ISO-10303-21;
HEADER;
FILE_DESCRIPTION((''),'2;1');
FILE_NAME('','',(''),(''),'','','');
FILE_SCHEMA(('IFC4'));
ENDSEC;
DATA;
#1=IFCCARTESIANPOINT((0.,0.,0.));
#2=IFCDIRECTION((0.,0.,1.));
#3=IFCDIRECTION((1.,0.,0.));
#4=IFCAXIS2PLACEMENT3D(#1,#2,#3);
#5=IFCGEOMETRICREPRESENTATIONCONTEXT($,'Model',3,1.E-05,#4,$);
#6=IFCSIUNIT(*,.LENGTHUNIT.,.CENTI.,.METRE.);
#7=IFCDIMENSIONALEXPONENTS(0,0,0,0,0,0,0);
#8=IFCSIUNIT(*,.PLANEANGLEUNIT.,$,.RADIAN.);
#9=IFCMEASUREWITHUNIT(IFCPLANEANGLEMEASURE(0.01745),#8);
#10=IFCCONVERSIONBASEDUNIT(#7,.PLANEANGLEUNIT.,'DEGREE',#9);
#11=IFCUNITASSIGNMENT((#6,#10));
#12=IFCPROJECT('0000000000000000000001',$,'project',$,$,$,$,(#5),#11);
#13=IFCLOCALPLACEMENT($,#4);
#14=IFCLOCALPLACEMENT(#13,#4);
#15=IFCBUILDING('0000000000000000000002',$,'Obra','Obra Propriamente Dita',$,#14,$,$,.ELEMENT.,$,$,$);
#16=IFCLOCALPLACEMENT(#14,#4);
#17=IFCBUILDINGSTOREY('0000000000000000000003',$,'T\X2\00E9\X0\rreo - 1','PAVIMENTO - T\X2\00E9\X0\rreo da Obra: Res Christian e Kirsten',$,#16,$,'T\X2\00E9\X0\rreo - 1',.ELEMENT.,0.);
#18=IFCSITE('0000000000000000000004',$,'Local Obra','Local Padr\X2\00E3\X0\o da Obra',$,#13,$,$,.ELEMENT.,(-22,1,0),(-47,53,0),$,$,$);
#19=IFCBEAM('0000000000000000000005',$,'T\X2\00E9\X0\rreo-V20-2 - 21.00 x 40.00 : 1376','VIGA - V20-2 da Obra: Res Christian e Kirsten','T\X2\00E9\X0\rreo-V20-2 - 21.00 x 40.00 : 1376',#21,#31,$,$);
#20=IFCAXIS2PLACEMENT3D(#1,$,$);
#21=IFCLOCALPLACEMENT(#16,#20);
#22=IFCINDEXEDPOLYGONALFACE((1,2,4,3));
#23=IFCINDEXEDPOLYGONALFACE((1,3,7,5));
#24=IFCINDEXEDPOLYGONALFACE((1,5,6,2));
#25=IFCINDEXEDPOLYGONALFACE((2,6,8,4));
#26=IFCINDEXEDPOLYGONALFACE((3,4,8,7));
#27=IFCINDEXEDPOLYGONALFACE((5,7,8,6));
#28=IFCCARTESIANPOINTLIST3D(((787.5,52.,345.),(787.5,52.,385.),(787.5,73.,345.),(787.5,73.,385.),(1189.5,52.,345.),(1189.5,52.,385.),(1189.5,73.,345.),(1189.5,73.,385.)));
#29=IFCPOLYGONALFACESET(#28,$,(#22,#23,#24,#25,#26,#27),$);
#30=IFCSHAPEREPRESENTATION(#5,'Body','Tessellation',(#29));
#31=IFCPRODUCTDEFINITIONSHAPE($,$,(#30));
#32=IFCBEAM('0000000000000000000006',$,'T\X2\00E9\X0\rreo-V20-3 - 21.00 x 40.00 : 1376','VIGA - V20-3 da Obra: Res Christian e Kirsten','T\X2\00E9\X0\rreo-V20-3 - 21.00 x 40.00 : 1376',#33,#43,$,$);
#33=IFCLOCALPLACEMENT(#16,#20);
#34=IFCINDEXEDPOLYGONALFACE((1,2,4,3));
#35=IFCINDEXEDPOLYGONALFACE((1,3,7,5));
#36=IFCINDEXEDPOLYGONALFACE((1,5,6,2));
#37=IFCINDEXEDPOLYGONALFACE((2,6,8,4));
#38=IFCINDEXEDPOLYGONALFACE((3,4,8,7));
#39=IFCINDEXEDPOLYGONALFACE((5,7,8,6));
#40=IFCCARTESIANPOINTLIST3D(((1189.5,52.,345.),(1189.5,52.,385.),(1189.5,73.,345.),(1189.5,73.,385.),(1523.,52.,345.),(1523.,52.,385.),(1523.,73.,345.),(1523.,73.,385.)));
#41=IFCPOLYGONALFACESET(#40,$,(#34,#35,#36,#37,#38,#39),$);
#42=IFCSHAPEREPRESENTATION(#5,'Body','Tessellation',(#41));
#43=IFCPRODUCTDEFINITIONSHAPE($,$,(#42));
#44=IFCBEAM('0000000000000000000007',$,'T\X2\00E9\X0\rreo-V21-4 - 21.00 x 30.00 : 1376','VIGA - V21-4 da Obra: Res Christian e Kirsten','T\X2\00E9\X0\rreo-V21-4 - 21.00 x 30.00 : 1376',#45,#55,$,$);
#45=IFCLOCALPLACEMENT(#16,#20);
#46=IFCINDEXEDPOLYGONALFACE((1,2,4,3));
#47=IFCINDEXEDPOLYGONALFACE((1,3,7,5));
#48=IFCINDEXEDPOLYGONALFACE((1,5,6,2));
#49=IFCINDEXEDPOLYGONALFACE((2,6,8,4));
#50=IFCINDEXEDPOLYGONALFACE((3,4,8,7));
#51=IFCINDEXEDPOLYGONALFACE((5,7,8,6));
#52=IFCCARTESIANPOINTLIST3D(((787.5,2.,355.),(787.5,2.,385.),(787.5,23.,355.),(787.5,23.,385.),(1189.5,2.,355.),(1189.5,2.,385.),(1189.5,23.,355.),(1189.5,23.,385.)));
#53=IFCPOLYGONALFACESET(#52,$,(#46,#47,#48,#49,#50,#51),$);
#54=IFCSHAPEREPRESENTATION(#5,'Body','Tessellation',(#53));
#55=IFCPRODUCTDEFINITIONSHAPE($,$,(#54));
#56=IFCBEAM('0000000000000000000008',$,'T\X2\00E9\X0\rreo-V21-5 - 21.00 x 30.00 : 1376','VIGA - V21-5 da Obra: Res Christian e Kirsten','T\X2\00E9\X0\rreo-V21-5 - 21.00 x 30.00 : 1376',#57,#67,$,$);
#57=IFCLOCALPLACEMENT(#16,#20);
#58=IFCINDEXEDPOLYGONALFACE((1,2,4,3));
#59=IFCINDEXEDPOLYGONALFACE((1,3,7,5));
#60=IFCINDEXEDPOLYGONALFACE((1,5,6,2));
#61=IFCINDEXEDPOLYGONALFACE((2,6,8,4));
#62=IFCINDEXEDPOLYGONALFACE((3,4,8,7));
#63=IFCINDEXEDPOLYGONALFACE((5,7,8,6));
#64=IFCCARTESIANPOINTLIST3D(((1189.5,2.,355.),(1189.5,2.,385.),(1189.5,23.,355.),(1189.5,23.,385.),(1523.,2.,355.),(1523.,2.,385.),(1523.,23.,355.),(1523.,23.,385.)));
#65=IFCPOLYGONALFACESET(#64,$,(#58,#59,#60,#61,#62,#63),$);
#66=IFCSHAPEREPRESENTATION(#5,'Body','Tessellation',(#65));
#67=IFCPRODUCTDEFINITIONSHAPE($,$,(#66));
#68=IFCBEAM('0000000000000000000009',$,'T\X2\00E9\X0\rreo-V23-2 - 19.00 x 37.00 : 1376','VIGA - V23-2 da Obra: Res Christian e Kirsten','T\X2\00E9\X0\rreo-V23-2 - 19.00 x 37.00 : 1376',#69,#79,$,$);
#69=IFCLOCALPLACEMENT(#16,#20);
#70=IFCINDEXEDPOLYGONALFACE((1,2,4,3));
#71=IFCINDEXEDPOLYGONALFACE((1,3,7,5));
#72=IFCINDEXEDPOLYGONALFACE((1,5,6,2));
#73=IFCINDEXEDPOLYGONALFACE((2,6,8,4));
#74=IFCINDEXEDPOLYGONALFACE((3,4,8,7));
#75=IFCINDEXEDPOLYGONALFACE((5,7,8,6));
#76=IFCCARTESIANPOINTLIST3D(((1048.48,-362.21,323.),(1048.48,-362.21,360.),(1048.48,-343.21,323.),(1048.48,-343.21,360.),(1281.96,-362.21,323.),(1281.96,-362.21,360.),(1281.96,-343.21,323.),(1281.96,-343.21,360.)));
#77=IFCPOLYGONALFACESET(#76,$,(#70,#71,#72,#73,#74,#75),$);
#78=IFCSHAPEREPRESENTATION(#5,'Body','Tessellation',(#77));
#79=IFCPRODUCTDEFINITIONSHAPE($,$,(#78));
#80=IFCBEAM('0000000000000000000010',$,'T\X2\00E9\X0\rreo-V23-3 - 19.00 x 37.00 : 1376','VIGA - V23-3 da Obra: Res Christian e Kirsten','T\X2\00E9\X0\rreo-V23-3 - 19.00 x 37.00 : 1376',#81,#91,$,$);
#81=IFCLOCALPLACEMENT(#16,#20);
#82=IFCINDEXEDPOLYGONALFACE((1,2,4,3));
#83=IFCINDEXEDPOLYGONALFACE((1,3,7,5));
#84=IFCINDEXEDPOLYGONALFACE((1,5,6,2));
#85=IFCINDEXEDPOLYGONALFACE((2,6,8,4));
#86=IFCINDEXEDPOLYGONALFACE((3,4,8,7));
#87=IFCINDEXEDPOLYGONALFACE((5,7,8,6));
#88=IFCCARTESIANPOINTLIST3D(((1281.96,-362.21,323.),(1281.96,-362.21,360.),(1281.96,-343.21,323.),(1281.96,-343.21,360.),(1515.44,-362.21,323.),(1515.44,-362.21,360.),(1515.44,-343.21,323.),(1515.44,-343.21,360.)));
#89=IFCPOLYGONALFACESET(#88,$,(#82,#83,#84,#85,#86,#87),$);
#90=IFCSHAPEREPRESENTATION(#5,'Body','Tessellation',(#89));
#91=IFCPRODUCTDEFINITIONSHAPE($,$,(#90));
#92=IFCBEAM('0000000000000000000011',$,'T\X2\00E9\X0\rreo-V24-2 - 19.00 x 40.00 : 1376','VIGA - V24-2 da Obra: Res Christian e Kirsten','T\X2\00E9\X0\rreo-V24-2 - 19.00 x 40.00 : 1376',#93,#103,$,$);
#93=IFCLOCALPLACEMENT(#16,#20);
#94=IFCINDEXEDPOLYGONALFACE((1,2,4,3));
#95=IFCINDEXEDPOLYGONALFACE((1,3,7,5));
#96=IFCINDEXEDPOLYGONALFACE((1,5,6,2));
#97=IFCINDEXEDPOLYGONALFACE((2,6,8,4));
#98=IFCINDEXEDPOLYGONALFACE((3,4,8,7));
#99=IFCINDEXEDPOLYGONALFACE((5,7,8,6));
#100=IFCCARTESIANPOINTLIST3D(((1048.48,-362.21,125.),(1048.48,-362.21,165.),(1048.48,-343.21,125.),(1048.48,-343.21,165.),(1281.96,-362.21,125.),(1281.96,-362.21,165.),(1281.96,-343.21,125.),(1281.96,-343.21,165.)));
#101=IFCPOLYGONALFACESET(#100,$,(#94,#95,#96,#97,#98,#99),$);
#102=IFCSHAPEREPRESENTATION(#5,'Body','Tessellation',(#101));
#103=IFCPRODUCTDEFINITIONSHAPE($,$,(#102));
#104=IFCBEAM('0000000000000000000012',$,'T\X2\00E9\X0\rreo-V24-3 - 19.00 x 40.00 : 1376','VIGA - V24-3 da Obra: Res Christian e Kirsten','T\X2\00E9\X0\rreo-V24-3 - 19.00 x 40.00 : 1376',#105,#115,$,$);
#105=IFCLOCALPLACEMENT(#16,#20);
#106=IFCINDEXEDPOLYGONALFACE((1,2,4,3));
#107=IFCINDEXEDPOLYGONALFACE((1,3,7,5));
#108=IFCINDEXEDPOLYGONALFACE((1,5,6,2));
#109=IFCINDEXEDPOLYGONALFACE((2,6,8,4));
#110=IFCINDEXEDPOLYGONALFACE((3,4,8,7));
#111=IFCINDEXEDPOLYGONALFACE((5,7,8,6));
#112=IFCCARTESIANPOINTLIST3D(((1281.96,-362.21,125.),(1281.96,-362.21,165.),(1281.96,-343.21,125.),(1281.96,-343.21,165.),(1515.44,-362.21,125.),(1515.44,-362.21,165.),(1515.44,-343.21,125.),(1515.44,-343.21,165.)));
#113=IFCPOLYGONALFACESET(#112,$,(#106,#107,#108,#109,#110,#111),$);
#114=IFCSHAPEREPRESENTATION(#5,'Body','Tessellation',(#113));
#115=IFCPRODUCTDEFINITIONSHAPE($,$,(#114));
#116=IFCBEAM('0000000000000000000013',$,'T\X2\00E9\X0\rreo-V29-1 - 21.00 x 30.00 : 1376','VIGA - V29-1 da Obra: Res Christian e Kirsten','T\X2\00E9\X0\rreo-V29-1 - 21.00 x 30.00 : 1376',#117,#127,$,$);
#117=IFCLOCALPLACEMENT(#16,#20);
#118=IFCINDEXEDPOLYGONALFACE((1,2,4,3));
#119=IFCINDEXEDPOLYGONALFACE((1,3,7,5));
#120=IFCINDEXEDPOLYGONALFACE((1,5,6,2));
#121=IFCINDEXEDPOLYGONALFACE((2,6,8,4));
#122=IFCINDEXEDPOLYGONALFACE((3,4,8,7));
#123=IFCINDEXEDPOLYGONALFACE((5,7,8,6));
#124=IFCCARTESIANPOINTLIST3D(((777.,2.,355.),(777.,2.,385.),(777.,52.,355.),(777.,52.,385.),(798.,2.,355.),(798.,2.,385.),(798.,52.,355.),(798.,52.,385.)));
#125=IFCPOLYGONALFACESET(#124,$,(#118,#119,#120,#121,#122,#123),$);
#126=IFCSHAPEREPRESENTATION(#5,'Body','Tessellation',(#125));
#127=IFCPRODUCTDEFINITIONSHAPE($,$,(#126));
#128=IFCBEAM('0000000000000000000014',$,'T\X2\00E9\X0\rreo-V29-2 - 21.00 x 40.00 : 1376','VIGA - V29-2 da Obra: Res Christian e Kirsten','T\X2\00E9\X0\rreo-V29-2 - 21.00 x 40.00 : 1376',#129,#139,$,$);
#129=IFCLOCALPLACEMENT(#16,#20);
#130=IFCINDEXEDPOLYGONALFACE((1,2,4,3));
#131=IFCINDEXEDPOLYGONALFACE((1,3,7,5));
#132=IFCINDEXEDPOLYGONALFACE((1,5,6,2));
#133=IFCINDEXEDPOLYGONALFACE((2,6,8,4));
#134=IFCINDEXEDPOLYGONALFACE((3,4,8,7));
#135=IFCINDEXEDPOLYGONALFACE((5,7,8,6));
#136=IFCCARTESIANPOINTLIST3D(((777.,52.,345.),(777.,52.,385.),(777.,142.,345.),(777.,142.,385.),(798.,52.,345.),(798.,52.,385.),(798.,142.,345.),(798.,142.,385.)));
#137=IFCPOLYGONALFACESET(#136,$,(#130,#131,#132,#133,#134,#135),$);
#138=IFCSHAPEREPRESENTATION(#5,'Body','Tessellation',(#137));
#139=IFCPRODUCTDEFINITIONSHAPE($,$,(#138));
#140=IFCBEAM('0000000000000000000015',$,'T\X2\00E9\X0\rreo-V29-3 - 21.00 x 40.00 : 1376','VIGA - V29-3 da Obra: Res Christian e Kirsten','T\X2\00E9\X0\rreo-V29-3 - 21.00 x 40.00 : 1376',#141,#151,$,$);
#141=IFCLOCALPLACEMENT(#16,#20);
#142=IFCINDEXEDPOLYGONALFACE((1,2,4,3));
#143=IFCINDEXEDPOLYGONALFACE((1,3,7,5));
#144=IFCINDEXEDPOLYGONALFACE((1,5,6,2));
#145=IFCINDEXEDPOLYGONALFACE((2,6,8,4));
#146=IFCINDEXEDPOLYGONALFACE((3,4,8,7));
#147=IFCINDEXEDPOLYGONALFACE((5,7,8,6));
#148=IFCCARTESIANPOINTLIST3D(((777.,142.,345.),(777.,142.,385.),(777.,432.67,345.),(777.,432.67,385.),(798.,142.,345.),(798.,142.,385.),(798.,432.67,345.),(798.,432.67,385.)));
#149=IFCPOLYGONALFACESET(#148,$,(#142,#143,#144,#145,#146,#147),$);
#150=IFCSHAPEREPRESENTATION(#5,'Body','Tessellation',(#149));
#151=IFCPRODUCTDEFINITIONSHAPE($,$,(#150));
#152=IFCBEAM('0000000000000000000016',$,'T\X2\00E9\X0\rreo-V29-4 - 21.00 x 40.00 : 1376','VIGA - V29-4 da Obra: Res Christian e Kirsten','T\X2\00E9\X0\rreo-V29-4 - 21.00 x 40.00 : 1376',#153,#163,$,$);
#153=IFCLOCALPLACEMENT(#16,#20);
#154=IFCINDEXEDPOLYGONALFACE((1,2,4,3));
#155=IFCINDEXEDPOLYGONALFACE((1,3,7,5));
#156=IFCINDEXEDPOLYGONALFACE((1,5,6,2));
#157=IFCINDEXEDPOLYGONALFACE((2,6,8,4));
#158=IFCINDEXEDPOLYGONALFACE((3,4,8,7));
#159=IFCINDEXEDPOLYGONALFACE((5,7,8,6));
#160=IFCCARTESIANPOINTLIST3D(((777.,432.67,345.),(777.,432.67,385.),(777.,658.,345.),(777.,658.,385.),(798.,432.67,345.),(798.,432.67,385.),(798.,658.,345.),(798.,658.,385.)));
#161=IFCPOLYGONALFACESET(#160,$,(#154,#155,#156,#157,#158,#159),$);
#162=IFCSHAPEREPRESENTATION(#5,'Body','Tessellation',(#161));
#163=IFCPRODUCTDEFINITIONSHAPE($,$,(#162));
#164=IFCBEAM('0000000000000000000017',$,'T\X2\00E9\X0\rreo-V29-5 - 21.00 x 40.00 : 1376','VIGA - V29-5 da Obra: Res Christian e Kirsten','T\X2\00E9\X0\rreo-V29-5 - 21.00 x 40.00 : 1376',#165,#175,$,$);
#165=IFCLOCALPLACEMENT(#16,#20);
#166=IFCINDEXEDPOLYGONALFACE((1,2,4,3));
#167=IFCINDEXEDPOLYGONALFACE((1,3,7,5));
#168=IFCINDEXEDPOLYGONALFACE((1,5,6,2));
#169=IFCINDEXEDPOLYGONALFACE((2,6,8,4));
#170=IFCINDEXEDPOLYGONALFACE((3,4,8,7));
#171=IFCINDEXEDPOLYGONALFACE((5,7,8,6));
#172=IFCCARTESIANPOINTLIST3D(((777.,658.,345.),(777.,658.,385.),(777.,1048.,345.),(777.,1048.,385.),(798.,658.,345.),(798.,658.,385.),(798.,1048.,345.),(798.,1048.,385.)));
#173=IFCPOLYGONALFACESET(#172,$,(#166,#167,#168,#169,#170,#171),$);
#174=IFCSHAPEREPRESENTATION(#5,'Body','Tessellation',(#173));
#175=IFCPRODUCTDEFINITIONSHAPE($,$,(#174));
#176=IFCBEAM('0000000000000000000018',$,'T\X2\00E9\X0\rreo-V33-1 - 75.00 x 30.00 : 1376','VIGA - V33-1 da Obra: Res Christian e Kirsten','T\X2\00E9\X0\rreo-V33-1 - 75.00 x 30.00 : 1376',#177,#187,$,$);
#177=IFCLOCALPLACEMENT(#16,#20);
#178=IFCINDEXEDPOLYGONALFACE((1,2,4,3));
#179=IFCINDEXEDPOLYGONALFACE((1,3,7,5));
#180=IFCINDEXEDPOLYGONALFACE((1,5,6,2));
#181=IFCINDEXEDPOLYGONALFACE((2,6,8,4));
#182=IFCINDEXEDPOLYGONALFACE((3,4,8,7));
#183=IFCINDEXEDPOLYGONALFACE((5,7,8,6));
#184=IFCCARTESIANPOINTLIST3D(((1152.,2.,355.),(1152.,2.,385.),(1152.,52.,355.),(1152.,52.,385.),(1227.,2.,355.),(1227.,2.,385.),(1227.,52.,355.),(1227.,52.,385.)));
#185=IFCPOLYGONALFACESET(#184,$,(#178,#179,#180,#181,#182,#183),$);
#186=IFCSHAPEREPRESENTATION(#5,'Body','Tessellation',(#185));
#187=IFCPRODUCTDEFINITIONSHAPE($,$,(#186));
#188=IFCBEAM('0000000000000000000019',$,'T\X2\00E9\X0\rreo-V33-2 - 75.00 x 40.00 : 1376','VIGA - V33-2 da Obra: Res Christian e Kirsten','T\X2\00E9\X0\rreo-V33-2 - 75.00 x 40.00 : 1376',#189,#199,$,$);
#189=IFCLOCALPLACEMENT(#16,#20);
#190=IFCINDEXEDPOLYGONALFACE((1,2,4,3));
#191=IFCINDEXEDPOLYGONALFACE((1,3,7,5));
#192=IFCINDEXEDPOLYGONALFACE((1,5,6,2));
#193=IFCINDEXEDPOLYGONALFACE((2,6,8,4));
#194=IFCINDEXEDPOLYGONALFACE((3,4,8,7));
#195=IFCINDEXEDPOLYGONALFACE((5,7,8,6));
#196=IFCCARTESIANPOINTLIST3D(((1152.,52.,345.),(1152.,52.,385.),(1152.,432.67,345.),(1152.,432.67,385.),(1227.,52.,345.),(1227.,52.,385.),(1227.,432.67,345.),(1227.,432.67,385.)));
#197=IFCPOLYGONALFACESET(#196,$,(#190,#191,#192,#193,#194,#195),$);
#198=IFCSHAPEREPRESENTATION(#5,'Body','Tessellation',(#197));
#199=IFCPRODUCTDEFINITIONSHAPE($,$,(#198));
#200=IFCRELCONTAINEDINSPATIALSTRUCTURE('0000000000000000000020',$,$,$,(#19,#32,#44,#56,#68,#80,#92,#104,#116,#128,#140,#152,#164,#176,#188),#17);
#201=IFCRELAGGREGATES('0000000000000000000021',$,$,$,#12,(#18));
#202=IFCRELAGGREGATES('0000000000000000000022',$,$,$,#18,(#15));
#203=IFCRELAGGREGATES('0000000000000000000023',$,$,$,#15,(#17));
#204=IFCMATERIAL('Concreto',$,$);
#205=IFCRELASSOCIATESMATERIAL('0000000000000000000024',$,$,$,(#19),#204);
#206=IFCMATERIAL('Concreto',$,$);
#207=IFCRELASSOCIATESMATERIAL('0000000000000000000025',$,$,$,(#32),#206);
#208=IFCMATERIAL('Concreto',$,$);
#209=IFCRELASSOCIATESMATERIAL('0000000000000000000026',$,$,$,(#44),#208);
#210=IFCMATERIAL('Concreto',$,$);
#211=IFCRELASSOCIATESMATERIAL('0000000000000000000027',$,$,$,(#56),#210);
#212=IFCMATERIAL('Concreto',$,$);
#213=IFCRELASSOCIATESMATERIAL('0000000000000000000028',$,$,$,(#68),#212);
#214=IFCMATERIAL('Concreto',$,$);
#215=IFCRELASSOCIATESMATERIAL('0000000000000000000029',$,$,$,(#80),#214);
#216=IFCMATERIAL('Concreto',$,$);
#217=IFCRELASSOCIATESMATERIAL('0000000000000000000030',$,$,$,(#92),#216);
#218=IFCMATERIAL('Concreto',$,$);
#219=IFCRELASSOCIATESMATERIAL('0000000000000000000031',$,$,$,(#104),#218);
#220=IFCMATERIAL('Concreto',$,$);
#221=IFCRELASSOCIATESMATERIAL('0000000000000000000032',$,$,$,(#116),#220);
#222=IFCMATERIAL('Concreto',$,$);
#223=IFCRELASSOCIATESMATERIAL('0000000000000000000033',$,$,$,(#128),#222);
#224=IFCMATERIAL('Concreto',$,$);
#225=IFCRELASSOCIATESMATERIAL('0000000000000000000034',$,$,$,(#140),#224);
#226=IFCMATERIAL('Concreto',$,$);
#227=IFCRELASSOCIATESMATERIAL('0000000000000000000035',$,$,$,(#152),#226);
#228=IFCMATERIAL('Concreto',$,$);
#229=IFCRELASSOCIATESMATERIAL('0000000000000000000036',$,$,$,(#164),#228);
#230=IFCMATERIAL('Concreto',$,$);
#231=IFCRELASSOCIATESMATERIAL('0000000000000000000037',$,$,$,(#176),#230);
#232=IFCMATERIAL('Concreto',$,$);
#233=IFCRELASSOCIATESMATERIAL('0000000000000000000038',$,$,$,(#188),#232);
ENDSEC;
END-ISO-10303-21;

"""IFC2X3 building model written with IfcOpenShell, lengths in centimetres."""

from ifc_helpers import new_model, entity, si_unit, converted_unit, frame, origin_with_axes, place, context, project, spatial, polyline, outline, extrude, material, element, save


model = new_model("IFC2X3")

# Units and contexts
model_context = context("Model", 3, precision=1e-05, world=origin_with_axes())
ifc_project = project(units=[si_unit("LENGTHUNIT", "METRE", prefix="CENTI"), converted_unit("PLANEANGLEUNIT", "DEGREE", entity("IfcPlaneAngleMeasure", 0.01745), si_unit("PLANEANGLEUNIT", "RADIAN"), dimensions=[0, 0, 0, 0, 0, 0, 0])], contexts=[model_context])

# Site, building, storey
site_placement = place(None, origin_with_axes())
site = spatial("IfcSite", under=ifc_project, at=site_placement, Name="Local Obra", Description="Local Padrão da Obra", CompositionType="ELEMENT", RefLatitude=(-22, 1, 0), RefLongitude=(-47, 53, 0))
building_placement = place(site_placement, origin_with_axes())
building = spatial("IfcBuilding", under=site, at=building_placement, Name="Obra", Description="Obra Propriamente Dita", CompositionType="ELEMENT")
storey_placement = place(building_placement, origin_with_axes())
storey = spatial("IfcBuildingStorey", under=building, at=storey_placement, Name="Térreo - 1", Description="PAVIMENTO - Térreo da Obra: Res Christian e Kirsten", LongName="Térreo - 1", CompositionType="ELEMENT", Elevation=0.0)

# Beams
ifc_material_1 = material(Name="Concreto")
beam_1_placement = place(storey_placement, frame((787.5, 52.0, 385.0), z_axis=(1.0, 0.0, 0.0), x_axis=(0.0, -1.0, 0.0)))
element("IfcBeam", 1, at=beam_1_placement, inside=storey, material=ifc_material_1, Name="Térreo-V20-2 - 21.00 x 40.00 : 1376", Description="VIGA - V20-2 da Obra: Res Christian e Kirsten", ObjectType="Térreo-V20-2 - 21.00 x 40.00 : 1376", context=model_context, shape_type="SweptSolid", body=[
    extrude(outline(polyline([(-21.0, 0.0), (0.0, 0.0), (0.0, 40.0), (-21.0, 40.0), (-21.0, 0.0)])), origin_with_axes(), (0.0, 0.0, 1.0), 402.0),
])
ifc_material_2 = material(Name="Concreto")
beam_2_placement = place(storey_placement, frame((1189.5, 52.0, 385.0), z_axis=(1.0, 0.0, 0.0), x_axis=(0.0, -1.0, 0.0)))
element("IfcBeam", 2, at=beam_2_placement, inside=storey, material=ifc_material_2, Name="Térreo-V20-3 - 21.00 x 40.00 : 1376", Description="VIGA - V20-3 da Obra: Res Christian e Kirsten", ObjectType="Térreo-V20-3 - 21.00 x 40.00 : 1376", context=model_context, shape_type="SweptSolid", body=[
    extrude(outline(polyline([(-21.0, 0.0), (0.0, 0.0), (0.0, 40.0), (-21.0, 40.0), (-21.0, 0.0)])), origin_with_axes(), (0.0, 0.0, 1.0), 333.5),
])
ifc_material_3 = material(Name="Concreto")
beam_3_placement = place(storey_placement, frame((787.5, 2.0, 385.0), z_axis=(1.0, 0.0, 0.0), x_axis=(0.0, -1.0, 0.0)))
element("IfcBeam", 3, at=beam_3_placement, inside=storey, material=ifc_material_3, Name="Térreo-V21-4 - 21.00 x 30.00 : 1376", Description="VIGA - V21-4 da Obra: Res Christian e Kirsten", ObjectType="Térreo-V21-4 - 21.00 x 30.00 : 1376", context=model_context, shape_type="SweptSolid", body=[
    extrude(outline(polyline([(-21.0, 0.0), (0.0, 0.0), (0.0, 30.0), (-21.0, 30.0), (-21.0, 0.0)])), origin_with_axes(), (0.0, 0.0, 1.0), 402.0),
])
ifc_material_4 = material(Name="Concreto")
beam_4_placement = place(storey_placement, frame((1189.5, 2.0, 385.0), z_axis=(1.0, 0.0, 0.0), x_axis=(0.0, -1.0, 0.0)))
element("IfcBeam", 4, at=beam_4_placement, inside=storey, material=ifc_material_4, Name="Térreo-V21-5 - 21.00 x 30.00 : 1376", Description="VIGA - V21-5 da Obra: Res Christian e Kirsten", ObjectType="Térreo-V21-5 - 21.00 x 30.00 : 1376", context=model_context, shape_type="SweptSolid", body=[
    extrude(outline(polyline([(-21.0, 0.0), (0.0, 0.0), (0.0, 30.0), (-21.0, 30.0), (-21.0, 0.0)])), origin_with_axes(), (0.0, 0.0, 1.0), 333.5),
])
ifc_material_5 = material(Name="Concreto")
beam_5_placement = place(storey_placement, frame((1048.48, -362.21, 360.0), z_axis=(1.0, 0.0, 0.0), x_axis=(0.0, -1.0, 0.0)))
element("IfcBeam", 5, at=beam_5_placement, inside=storey, material=ifc_material_5, Name="Térreo-V23-2 - 19.00 x 37.00 : 1376", Description="VIGA - V23-2 da Obra: Res Christian e Kirsten", ObjectType="Térreo-V23-2 - 19.00 x 37.00 : 1376", context=model_context, shape_type="SweptSolid", body=[
    extrude(outline(polyline([(-19.0, 0.0), (0.0, 0.0), (0.0, 37.0), (-19.0, 37.0), (-19.0, 0.0)])), origin_with_axes(), (0.0, 0.0, 1.0), 233.48),
])
ifc_material_6 = material(Name="Concreto")
beam_6_placement = place(storey_placement, frame((1281.96, -362.21, 360.0), z_axis=(1.0, 0.0, 0.0), x_axis=(0.0, -1.0, 0.0)))
element("IfcBeam", 6, at=beam_6_placement, inside=storey, material=ifc_material_6, Name="Térreo-V23-3 - 19.00 x 37.00 : 1376", Description="VIGA - V23-3 da Obra: Res Christian e Kirsten", ObjectType="Térreo-V23-3 - 19.00 x 37.00 : 1376", context=model_context, shape_type="SweptSolid", body=[
    extrude(outline(polyline([(-19.0, 0.0), (0.0, 0.0), (0.0, 37.0), (-19.0, 37.0), (-19.0, 0.0)])), origin_with_axes(), (0.0, 0.0, 1.0), 233.48),
])
ifc_material_7 = material(Name="Concreto")
beam_7_placement = place(storey_placement, frame((1048.48, -362.21, 165.0), z_axis=(1.0, 0.0, 0.0), x_axis=(0.0, -1.0, 0.0)))
element("IfcBeam", 7, at=beam_7_placement, inside=storey, material=ifc_material_7, Name="Térreo-V24-2 - 19.00 x 40.00 : 1376", Description="VIGA - V24-2 da Obra: Res Christian e Kirsten", ObjectType="Térreo-V24-2 - 19.00 x 40.00 : 1376", context=model_context, shape_type="SweptSolid", body=[
    extrude(outline(polyline([(-19.0, 0.0), (0.0, 0.0), (0.0, 40.0), (-19.0, 40.0), (-19.0, 0.0)])), origin_with_axes(), (0.0, 0.0, 1.0), 233.48),
])
ifc_material_8 = material(Name="Concreto")
beam_8_placement = place(storey_placement, frame((1281.96, -362.21, 165.0), z_axis=(1.0, 0.0, 0.0), x_axis=(0.0, -1.0, 0.0)))
element("IfcBeam", 8, at=beam_8_placement, inside=storey, material=ifc_material_8, Name="Térreo-V24-3 - 19.00 x 40.00 : 1376", Description="VIGA - V24-3 da Obra: Res Christian e Kirsten", ObjectType="Térreo-V24-3 - 19.00 x 40.00 : 1376", context=model_context, shape_type="SweptSolid", body=[
    extrude(outline(polyline([(-19.0, 0.0), (0.0, 0.0), (0.0, 40.0), (-19.0, 40.0), (-19.0, 0.0)])), origin_with_axes(), (0.0, 0.0, 1.0), 233.48),
])
ifc_material_9 = material(Name="Concreto")
beam_9_placement = place(storey_placement, frame((787.5, 2.0, 385.0), z_axis=(0.0, 1.0, 0.0), x_axis=(1.0, 0.0, 0.0)))
element("IfcBeam", 9, at=beam_9_placement, inside=storey, material=ifc_material_9, Name="Térreo-V29-1 - 21.00 x 30.00 : 1376", Description="VIGA - V29-1 da Obra: Res Christian e Kirsten", ObjectType="Térreo-V29-1 - 21.00 x 30.00 : 1376", context=model_context, shape_type="SweptSolid", body=[
    extrude(outline(polyline([(-10.5, 0.0), (10.5, 0.0), (10.5, 30.0), (-10.5, 30.0), (-10.5, 0.0)])), origin_with_axes(), (0.0, 0.0, 1.0), 50.0),
])
ifc_material_10 = material(Name="Concreto")
beam_10_placement = place(storey_placement, frame((787.5, 52.0, 385.0), z_axis=(-0.000002, 1.0, 0.0), x_axis=(1.0, 0.000002, 0.0)))
element("IfcBeam", 10, at=beam_10_placement, inside=storey, material=ifc_material_10, Name="Térreo-V29-2 - 21.00 x 40.00 : 1376", Description="VIGA - V29-2 da Obra: Res Christian e Kirsten", ObjectType="Térreo-V29-2 - 21.00 x 40.00 : 1376", context=model_context, shape_type="SweptSolid", body=[
    extrude(outline(polyline([(-10.5, 0.0), (10.5, 0.0), (10.5, 40.0), (-10.5, 40.0), (-10.5, 0.0)])), origin_with_axes(), (0.0, 0.0, 1.0), 90.0),
])
ifc_material_11 = material(Name="Concreto")
beam_11_placement = place(storey_placement, frame((787.5, 142.0, 385.0), z_axis=(0.0, 1.0, 0.0), x_axis=(1.0, 0.0, 0.0)))
element("IfcBeam", 11, at=beam_11_placement, inside=storey, material=ifc_material_11, Name="Térreo-V29-3 - 21.00 x 40.00 : 1376", Description="VIGA - V29-3 da Obra: Res Christian e Kirsten", ObjectType="Térreo-V29-3 - 21.00 x 40.00 : 1376", context=model_context, shape_type="SweptSolid", body=[
    extrude(outline(polyline([(-10.5, 0.0), (10.5, 0.0), (10.5, 40.0), (-10.5, 40.0), (-10.5, 0.0)])), origin_with_axes(), (0.0, 0.0, 1.0), 290.67),
])
ifc_material_12 = material(Name="Concreto")
beam_12_placement = place(storey_placement, frame((787.5, 432.67, 385.0), z_axis=(0.0, 1.0, 0.0), x_axis=(1.0, 0.0, 0.0)))
element("IfcBeam", 12, at=beam_12_placement, inside=storey, material=ifc_material_12, Name="Térreo-V29-4 - 21.00 x 40.00 : 1376", Description="VIGA - V29-4 da Obra: Res Christian e Kirsten", ObjectType="Térreo-V29-4 - 21.00 x 40.00 : 1376", context=model_context, shape_type="SweptSolid", body=[
    extrude(outline(polyline([(-10.5, 0.0), (10.5, 0.0), (10.5, 40.0), (-10.5, 40.0), (-10.5, 0.0)])), origin_with_axes(), (0.0, 0.0, 1.0), 225.33),
])
ifc_material_13 = material(Name="Concreto")
beam_13_placement = place(storey_placement, frame((787.5, 658.0, 385.0), z_axis=(0.0, 1.0, 0.0), x_axis=(1.0, 0.0, 0.0)))
element("IfcBeam", 13, at=beam_13_placement, inside=storey, material=ifc_material_13, Name="Térreo-V29-5 - 21.00 x 40.00 : 1376", Description="VIGA - V29-5 da Obra: Res Christian e Kirsten", ObjectType="Térreo-V29-5 - 21.00 x 40.00 : 1376", context=model_context, shape_type="SweptSolid", body=[
    extrude(outline(polyline([(-10.5, 0.0), (10.5, 0.0), (10.5, 40.0), (-10.5, 40.0), (-10.5, 0.0)])), origin_with_axes(), (0.0, 0.0, 1.0), 390.0),
])
ifc_material_14 = material(Name="Concreto")
beam_14_placement = place(storey_placement, frame((1189.5, 2.0, 385.0), z_axis=(0.0, 1.0, 0.0), x_axis=(1.0, 0.0, 0.0)))
element("IfcBeam", 14, at=beam_14_placement, inside=storey, material=ifc_material_14, Name="Térreo-V33-1 - 75.00 x 30.00 : 1376", Description="VIGA - V33-1 da Obra: Res Christian e Kirsten", ObjectType="Térreo-V33-1 - 75.00 x 30.00 : 1376", context=model_context, shape_type="SweptSolid", body=[
    extrude(outline(polyline([(-37.5, 0.0), (37.5, 0.0), (37.5, 30.0), (-37.5, 30.0), (-37.5, 0.0)])), origin_with_axes(), (0.0, 0.0, 1.0), 50.0),
])
ifc_material_15 = material(Name="Concreto")
beam_15_placement = place(storey_placement, frame((1189.5, 52.0, 385.0), z_axis=(0.0, 1.0, 0.0), x_axis=(1.0, 0.0, 0.0)))
element("IfcBeam", 15, at=beam_15_placement, inside=storey, material=ifc_material_15, Name="Térreo-V33-2 - 75.00 x 40.00 : 1376", Description="VIGA - V33-2 da Obra: Res Christian e Kirsten", ObjectType="Térreo-V33-2 - 75.00 x 40.00 : 1376", context=model_context, shape_type="SweptSolid", body=[
    extrude(outline(polyline([(-37.5, 0.0), (37.5, 0.0), (37.5, 40.0), (-37.5, 40.0), (-37.5, 0.0)])), origin_with_axes(), (0.0, 0.0, 1.0), 380.67),
])

save(model, "model.ifc")
